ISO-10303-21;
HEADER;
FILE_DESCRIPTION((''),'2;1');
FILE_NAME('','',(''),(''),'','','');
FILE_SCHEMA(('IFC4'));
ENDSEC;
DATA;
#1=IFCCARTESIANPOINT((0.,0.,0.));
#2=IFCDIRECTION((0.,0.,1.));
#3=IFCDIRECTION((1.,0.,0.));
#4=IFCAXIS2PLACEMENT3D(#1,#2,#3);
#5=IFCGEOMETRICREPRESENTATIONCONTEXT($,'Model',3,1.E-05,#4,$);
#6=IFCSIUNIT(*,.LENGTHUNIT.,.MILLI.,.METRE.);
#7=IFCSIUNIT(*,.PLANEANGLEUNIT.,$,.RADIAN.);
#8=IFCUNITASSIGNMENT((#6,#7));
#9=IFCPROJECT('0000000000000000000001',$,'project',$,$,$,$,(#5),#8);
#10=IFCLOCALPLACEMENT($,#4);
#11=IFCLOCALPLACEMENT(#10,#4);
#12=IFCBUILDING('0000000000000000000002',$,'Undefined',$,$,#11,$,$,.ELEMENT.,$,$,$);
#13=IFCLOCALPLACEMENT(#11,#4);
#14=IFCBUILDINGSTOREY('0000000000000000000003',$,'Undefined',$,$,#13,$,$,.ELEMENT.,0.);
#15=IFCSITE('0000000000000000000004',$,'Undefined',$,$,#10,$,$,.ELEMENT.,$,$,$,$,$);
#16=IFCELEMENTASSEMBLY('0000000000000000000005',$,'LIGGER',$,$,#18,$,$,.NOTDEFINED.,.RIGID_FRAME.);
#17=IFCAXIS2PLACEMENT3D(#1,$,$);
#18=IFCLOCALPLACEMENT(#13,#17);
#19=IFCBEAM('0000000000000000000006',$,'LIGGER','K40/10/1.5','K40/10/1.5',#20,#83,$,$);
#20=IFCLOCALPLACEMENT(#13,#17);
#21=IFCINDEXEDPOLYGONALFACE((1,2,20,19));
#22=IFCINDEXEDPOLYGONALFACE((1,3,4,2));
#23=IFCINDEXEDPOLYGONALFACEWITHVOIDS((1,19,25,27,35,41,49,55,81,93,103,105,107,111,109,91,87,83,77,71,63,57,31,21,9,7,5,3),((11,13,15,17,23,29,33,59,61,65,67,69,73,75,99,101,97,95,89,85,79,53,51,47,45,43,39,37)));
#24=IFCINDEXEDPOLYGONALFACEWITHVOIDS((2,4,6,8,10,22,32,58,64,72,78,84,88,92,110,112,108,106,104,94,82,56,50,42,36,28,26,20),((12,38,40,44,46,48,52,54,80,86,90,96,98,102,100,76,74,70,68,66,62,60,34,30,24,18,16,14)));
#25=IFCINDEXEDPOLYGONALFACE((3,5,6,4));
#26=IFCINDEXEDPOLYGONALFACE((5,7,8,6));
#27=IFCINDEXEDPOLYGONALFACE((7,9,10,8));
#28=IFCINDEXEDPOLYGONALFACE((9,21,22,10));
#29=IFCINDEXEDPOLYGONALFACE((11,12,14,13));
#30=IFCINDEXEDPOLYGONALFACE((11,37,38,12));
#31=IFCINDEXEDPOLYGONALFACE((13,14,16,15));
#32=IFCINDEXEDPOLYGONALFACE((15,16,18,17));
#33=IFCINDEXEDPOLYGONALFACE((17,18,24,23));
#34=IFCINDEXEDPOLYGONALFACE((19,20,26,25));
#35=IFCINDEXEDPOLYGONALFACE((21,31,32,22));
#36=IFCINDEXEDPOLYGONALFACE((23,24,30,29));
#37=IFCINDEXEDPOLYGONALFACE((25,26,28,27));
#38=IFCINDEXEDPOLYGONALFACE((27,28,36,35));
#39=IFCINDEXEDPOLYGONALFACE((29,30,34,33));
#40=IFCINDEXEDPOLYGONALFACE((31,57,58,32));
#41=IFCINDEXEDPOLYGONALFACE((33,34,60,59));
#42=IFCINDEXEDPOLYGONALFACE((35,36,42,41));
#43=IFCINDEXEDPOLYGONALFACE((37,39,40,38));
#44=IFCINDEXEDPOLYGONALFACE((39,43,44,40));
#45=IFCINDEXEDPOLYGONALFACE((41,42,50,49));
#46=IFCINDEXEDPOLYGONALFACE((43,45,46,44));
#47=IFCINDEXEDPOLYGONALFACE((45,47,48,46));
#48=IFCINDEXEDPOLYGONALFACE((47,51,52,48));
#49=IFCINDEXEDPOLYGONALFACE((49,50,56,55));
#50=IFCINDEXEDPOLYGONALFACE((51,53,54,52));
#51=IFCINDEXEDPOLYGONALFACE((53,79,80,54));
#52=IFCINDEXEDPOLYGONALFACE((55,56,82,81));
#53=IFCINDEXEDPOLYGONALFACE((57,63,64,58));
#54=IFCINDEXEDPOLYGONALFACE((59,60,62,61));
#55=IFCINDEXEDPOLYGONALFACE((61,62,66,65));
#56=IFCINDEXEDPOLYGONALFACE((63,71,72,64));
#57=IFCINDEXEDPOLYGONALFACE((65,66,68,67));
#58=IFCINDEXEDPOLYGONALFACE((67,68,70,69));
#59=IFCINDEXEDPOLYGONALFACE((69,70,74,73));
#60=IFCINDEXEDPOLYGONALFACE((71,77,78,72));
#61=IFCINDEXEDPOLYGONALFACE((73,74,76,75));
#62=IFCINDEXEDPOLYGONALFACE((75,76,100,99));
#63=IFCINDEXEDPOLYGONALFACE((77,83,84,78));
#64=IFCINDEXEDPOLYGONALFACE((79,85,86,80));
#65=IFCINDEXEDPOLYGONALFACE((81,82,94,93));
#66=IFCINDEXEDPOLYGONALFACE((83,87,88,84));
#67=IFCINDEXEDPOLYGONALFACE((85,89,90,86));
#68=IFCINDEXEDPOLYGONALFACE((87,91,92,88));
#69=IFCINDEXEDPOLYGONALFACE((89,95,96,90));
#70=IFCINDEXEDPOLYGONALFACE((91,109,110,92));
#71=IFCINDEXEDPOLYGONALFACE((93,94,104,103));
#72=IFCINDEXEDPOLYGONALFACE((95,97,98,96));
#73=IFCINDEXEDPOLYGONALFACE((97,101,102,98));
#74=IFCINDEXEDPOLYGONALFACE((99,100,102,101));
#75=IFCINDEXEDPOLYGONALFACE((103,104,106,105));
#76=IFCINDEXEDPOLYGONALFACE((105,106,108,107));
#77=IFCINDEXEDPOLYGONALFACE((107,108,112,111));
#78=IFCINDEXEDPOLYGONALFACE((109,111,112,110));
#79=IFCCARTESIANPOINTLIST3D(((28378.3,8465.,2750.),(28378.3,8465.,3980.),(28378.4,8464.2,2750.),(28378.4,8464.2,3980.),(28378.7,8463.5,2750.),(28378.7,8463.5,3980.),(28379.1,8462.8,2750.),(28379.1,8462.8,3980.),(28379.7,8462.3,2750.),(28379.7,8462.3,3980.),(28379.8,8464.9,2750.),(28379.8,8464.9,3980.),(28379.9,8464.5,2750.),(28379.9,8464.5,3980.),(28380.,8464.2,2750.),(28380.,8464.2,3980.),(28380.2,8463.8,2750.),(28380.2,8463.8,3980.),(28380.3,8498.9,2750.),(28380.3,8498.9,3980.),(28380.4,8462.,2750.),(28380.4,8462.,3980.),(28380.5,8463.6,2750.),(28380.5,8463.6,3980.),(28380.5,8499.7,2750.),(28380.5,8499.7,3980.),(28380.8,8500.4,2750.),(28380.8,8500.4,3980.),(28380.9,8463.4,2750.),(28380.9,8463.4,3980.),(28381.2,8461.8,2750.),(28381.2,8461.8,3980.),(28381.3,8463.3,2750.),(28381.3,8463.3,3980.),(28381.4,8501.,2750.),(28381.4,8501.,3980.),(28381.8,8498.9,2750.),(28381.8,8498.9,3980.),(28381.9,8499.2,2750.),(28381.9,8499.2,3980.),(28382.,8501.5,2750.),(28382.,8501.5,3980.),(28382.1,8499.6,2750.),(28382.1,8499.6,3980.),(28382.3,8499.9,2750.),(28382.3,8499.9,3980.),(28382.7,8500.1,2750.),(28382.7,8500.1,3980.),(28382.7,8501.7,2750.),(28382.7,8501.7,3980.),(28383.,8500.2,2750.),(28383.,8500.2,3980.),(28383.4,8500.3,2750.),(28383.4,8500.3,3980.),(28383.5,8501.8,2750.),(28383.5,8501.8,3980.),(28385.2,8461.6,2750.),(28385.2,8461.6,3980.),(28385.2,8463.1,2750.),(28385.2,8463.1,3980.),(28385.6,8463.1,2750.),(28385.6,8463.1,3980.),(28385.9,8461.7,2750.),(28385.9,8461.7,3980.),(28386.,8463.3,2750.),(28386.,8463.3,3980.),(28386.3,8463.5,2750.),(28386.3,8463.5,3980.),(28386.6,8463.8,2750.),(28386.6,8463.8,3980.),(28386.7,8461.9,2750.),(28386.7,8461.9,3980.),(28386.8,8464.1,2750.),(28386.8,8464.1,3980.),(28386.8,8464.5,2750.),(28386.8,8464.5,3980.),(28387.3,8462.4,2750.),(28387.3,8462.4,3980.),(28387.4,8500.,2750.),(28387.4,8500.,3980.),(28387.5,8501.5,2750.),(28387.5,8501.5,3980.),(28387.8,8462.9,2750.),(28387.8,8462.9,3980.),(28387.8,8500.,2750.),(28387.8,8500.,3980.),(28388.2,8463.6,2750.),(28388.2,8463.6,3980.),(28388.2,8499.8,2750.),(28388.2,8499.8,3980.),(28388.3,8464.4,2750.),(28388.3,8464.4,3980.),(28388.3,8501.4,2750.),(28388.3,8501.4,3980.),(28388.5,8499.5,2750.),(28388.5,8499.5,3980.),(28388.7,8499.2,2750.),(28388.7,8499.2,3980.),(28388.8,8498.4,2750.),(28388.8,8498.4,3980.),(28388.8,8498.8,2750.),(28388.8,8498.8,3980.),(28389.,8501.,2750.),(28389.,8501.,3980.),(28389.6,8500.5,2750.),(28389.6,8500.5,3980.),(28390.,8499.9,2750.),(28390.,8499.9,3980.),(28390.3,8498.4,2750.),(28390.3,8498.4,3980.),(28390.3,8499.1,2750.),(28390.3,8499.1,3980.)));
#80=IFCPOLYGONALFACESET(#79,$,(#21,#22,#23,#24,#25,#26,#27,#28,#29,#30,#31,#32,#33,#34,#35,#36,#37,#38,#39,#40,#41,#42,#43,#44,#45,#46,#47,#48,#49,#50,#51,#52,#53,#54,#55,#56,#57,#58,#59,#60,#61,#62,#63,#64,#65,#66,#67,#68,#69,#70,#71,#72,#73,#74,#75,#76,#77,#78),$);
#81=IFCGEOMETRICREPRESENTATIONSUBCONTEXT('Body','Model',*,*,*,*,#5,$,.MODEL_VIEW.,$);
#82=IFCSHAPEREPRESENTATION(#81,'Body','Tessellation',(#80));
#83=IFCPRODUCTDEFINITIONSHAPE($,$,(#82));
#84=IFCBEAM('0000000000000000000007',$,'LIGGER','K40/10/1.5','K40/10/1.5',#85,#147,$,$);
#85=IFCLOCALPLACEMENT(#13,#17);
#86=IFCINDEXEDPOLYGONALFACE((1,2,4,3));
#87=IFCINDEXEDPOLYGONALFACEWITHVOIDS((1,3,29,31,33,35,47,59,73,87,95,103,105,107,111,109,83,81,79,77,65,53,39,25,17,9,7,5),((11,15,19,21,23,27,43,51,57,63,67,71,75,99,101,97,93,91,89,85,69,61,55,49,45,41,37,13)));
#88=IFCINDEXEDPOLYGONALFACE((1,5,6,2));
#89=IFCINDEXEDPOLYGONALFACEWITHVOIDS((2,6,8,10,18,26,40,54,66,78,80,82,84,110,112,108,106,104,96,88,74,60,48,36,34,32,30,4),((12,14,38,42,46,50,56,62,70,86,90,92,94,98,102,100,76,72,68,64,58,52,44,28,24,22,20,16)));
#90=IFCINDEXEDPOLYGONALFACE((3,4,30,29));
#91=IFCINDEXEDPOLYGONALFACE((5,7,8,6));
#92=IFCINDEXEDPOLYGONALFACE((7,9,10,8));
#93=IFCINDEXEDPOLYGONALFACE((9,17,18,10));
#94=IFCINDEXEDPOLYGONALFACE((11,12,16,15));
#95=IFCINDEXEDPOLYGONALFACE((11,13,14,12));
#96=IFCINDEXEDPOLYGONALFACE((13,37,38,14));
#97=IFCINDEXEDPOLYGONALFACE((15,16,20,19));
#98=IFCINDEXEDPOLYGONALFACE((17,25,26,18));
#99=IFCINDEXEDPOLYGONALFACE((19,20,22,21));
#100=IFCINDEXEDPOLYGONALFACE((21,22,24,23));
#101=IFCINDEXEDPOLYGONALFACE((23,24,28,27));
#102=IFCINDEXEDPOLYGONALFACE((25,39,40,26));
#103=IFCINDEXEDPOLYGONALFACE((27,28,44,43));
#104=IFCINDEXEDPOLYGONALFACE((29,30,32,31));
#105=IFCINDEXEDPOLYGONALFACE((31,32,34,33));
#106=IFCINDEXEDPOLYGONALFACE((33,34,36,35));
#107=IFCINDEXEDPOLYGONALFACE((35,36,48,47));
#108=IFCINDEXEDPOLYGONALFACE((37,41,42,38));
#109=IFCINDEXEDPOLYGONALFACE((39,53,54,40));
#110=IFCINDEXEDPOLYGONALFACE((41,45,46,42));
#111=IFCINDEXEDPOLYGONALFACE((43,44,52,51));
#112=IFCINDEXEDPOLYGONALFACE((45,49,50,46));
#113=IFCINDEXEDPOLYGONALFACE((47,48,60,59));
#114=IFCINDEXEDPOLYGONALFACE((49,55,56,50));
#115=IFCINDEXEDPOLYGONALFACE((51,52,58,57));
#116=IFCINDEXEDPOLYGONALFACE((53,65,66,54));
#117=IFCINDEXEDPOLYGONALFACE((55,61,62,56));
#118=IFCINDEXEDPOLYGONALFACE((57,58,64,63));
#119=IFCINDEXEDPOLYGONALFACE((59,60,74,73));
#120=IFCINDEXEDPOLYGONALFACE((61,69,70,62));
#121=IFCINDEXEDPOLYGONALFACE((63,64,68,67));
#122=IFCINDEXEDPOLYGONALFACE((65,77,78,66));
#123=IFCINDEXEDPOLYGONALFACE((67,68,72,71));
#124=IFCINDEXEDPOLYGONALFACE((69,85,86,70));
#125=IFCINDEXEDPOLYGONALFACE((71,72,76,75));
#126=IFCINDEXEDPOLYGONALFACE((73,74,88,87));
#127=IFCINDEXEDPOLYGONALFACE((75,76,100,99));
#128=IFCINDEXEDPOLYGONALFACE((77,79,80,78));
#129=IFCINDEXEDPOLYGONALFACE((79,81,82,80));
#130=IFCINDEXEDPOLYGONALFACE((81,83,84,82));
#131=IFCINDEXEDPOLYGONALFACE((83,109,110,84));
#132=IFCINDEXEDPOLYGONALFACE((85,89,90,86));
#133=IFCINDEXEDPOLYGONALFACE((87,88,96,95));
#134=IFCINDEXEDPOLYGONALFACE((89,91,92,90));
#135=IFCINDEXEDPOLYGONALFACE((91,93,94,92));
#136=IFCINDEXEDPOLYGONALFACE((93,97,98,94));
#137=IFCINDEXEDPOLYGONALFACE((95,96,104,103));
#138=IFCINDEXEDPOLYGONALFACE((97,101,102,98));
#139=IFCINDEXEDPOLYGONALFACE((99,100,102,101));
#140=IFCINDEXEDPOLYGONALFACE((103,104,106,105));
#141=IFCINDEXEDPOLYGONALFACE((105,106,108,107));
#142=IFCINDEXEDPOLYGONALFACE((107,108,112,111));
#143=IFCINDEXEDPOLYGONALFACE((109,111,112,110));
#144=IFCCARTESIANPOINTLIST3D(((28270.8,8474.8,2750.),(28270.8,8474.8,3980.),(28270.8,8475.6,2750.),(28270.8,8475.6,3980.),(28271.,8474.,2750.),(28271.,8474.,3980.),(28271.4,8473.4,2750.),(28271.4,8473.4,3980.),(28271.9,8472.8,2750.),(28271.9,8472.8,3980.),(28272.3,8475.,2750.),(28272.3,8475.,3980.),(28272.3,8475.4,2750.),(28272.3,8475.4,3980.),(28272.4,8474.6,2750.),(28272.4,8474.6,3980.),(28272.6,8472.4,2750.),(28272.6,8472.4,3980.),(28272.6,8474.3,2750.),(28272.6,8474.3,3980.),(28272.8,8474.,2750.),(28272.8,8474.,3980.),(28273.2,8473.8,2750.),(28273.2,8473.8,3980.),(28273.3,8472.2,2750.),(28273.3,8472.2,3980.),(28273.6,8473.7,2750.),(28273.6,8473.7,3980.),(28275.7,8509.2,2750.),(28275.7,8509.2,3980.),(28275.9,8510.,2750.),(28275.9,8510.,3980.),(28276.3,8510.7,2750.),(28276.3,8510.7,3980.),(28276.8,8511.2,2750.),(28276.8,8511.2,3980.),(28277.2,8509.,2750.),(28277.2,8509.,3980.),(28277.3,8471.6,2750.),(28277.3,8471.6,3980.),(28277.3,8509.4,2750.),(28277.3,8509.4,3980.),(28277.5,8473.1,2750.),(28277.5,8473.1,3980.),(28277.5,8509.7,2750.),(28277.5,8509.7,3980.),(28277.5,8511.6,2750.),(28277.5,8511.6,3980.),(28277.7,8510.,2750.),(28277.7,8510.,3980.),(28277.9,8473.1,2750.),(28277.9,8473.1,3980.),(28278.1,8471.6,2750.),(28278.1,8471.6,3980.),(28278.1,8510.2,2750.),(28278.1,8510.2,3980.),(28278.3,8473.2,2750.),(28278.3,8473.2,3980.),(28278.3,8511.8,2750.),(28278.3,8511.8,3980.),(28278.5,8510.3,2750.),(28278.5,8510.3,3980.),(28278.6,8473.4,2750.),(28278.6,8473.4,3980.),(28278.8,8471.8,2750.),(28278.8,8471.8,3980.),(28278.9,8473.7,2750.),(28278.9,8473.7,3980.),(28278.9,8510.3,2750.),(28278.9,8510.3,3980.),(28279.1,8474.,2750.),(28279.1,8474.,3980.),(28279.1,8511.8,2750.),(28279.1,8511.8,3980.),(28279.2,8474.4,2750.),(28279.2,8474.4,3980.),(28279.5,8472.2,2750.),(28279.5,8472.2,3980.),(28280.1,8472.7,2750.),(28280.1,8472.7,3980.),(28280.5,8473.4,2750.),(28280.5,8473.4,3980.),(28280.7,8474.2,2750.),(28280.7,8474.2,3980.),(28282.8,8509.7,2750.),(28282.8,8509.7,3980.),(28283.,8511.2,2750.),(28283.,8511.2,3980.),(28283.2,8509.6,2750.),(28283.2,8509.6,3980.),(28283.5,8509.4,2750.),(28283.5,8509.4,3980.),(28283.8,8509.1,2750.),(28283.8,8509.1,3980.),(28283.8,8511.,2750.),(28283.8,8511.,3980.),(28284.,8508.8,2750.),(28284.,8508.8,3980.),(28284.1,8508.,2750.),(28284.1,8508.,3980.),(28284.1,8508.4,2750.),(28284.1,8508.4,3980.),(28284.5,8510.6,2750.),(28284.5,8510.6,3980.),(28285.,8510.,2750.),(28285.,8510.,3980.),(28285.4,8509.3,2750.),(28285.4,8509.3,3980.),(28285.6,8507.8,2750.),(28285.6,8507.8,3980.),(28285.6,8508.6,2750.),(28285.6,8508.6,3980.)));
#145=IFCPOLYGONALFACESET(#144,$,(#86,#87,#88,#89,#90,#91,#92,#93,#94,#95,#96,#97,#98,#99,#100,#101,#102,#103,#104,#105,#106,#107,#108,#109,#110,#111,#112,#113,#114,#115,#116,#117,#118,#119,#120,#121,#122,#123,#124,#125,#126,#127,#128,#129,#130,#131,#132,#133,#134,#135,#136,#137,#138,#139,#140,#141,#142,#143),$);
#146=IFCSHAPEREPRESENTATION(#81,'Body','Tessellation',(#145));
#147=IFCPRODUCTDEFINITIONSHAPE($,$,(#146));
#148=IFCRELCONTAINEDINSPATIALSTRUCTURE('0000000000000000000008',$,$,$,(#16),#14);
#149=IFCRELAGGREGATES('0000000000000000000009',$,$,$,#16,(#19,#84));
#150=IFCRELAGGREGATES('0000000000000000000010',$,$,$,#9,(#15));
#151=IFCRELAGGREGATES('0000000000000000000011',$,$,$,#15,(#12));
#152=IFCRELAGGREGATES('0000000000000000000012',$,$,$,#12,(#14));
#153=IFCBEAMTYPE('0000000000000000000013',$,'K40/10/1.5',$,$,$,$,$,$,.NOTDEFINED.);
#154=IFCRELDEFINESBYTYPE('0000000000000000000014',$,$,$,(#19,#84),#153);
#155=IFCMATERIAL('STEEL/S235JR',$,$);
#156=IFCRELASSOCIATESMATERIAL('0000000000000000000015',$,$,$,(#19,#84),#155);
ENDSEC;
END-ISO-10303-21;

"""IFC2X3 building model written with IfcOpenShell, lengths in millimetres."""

from ifc_helpers import new_model, si_unit, frame, origin_with_axes, origin_2d_with_axis, place, context, subcontext, project, spatial, hollow_rectangle, extrude, material, type_object, element, aggregate, save


model = new_model("IFC2X3")

# Units and contexts
model_context = context("Model", 3, precision=1e-05, world=origin_with_axes())
body_context = subcontext(model_context, "Body", "Model", "MODEL_VIEW")
ifc_project = project(units=[si_unit("LENGTHUNIT", "METRE", prefix="MILLI"), si_unit("PLANEANGLEUNIT", "RADIAN")], contexts=[model_context])

# Site, building, storey
site_placement = place(None, origin_with_axes())
site = spatial("IfcSite", under=ifc_project, at=site_placement, Name="Undefined", CompositionType="ELEMENT")
building_placement = place(site_placement, origin_with_axes())
building = spatial("IfcBuilding", under=site, at=building_placement, Name="Undefined", CompositionType="ELEMENT")
storey_placement = place(building_placement, origin_with_axes())
storey = spatial("IfcBuildingStorey", under=building, at=storey_placement, Name="Undefined", CompositionType="ELEMENT", Elevation=0.0)

# Element assembly, beams
ifc_material_1 = material(Name="STEEL/S235JR")
assembly_1_placement = place(storey_placement, origin_with_axes())
assembly_1 = element("IfcElementAssembly", 1, at=assembly_1_placement, inside=storey, Name="LIGGER", AssemblyPlace="NOTDEFINED", PredefinedType="RIGID_FRAME")
beam_type_1 = type_object("IfcBeamType", Name="K40/10/1.5", PredefinedType="NOTDEFINED")
beam_1_placement = place(assembly_1_placement, frame((28384.3, 8481.7, 3980.0), z_axis=(0.05886, 0.998266, 0.0), x_axis=(0.0, 0.0, -1.0)))
beam_1 = element("IfcBeam", 2, at=beam_1_placement, type_object=beam_type_1, material=ifc_material_1, Name="LIGGER", Description="K40/10/1.5", ObjectType="K40/10/1.5", context=body_context, shape_type="SweptSolid", body=[
    extrude(hollow_rectangle(XDim=10.0, YDim=40.0, WallThickness=1.5, InnerFilletRadius=1.5, OuterFilletRadius=3.0, at=origin_2d_with_axis()), frame((1230.0, 0.0, 0.0), z_axis=(-1.0, 0.0, 0.0), x_axis=(0.0, -1.0, 0.0)), (0.0, 0.0, 1.0), 1230.0),
])
beam_2_placement = place(assembly_1_placement, frame((28278.2, 8491.7, 3980.0), z_axis=(0.14305, 0.989716, 0.0), x_axis=(0.0, 0.0, -1.0)))
beam_2 = element("IfcBeam", 3, at=beam_2_placement, type_object=beam_type_1, material=ifc_material_1, Name="LIGGER", Description="K40/10/1.5", ObjectType="K40/10/1.5", context=body_context, shape_type="SweptSolid", body=[
    extrude(hollow_rectangle(XDim=10.0, YDim=40.0, WallThickness=1.5, InnerFilletRadius=1.5, OuterFilletRadius=3.0, at=origin_2d_with_axis()), frame((1230.0, 0.0, 0.0), z_axis=(-1.0, 0.0, 0.0), x_axis=(0.0, -1.0, 0.0)), (0.0, 0.0, 1.0), 1230.0),
])

aggregate(assembly_1, [beam_1, beam_2])

save(model, "model.ifc")
